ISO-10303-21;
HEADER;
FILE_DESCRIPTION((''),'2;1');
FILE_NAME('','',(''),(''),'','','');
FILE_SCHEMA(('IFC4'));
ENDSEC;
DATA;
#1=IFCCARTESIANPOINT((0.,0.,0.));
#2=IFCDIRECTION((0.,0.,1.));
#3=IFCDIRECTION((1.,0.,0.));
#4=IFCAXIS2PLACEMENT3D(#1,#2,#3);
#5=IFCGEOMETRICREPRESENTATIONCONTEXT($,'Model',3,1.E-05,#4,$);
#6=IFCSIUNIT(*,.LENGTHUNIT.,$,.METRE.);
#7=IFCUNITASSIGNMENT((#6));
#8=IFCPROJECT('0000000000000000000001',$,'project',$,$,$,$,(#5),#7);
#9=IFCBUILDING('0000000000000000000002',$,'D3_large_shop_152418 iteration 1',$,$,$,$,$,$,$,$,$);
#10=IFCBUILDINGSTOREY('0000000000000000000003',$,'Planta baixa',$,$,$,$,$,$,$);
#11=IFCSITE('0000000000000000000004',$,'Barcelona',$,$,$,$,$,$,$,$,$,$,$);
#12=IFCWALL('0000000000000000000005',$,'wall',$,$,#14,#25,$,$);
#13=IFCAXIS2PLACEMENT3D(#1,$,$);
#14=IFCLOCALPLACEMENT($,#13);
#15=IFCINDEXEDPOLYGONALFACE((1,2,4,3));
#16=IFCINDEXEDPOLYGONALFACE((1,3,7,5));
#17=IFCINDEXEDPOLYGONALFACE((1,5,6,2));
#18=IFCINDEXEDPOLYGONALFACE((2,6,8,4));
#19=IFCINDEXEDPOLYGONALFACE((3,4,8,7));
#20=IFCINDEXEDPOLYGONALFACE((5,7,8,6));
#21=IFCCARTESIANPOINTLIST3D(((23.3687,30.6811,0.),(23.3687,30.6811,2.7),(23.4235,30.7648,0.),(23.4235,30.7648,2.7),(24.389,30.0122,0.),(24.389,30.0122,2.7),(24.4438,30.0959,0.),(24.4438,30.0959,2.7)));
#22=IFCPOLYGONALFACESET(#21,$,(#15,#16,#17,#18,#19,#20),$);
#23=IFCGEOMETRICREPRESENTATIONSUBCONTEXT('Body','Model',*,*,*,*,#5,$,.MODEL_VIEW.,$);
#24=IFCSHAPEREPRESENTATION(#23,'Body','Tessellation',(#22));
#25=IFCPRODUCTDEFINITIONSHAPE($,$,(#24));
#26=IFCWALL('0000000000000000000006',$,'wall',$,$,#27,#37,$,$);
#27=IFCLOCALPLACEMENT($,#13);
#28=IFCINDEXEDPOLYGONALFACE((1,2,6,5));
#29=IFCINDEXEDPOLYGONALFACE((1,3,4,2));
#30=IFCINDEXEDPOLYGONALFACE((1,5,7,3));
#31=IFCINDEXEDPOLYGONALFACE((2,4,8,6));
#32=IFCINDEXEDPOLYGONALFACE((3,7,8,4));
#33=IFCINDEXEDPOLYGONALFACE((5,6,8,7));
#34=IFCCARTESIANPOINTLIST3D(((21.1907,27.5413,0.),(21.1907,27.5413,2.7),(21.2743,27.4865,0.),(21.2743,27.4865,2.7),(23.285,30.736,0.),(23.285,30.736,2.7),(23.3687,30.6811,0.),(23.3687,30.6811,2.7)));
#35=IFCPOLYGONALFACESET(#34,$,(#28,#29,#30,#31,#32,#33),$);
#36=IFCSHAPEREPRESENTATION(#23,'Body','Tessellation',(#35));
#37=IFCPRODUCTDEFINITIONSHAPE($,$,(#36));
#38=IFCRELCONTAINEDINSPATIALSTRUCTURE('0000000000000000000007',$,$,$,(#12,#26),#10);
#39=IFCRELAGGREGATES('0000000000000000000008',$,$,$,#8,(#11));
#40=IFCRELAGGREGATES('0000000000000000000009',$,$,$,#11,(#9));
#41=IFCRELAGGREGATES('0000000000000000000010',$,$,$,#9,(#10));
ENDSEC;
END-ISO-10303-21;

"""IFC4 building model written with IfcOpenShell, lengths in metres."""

from ifc_helpers import new_model, si_unit, origin, origin_with_axes, place, context, subcontext, project, spatial, polyline, outline, extrude, element, save


model = new_model("IFC4")

# Units and contexts
model_context = context("Model", 3, precision=1e-05, world=origin_with_axes())
body_context = subcontext(model_context, "Body", "Model", "MODEL_VIEW")
ifc_project = project(units=[si_unit("LENGTHUNIT", "METRE")], contexts=[model_context])

# Site, building, storey
site = spatial("IfcSite", under=ifc_project, Name="Barcelona")
building = spatial("IfcBuilding", under=site, Name="D3_large_shop_152418 iteration 1")
storey = spatial("IfcBuildingStorey", under=building, Name="Planta baixa")

# Walls
wall_1_placement = place(None, origin_with_axes())
element("IfcWall", 1, at=wall_1_placement, inside=storey, Name="wall", context=body_context, shape_type="SweptSolid", body=[
    extrude(outline(polyline([(24.389, 30.0122), (23.3687, 30.6811), (23.4235, 30.7648), (24.4438, 30.0959), (24.389, 30.0122)])), origin(), (0.0, 0.0, 1.0), 2.7),
])
wall_2_placement = place(None, origin_with_axes())
element("IfcWall", 2, at=wall_2_placement, inside=storey, Name="wall", context=body_context, shape_type="SweptSolid", body=[
    extrude(outline(polyline([(23.3687, 30.6811), (21.2743, 27.4865), (21.1907, 27.5413), (23.285, 30.736), (23.3687, 30.6811)])), origin(), (0.0, 0.0, 1.0), 2.7),
])

save(model, "model.ifc")
